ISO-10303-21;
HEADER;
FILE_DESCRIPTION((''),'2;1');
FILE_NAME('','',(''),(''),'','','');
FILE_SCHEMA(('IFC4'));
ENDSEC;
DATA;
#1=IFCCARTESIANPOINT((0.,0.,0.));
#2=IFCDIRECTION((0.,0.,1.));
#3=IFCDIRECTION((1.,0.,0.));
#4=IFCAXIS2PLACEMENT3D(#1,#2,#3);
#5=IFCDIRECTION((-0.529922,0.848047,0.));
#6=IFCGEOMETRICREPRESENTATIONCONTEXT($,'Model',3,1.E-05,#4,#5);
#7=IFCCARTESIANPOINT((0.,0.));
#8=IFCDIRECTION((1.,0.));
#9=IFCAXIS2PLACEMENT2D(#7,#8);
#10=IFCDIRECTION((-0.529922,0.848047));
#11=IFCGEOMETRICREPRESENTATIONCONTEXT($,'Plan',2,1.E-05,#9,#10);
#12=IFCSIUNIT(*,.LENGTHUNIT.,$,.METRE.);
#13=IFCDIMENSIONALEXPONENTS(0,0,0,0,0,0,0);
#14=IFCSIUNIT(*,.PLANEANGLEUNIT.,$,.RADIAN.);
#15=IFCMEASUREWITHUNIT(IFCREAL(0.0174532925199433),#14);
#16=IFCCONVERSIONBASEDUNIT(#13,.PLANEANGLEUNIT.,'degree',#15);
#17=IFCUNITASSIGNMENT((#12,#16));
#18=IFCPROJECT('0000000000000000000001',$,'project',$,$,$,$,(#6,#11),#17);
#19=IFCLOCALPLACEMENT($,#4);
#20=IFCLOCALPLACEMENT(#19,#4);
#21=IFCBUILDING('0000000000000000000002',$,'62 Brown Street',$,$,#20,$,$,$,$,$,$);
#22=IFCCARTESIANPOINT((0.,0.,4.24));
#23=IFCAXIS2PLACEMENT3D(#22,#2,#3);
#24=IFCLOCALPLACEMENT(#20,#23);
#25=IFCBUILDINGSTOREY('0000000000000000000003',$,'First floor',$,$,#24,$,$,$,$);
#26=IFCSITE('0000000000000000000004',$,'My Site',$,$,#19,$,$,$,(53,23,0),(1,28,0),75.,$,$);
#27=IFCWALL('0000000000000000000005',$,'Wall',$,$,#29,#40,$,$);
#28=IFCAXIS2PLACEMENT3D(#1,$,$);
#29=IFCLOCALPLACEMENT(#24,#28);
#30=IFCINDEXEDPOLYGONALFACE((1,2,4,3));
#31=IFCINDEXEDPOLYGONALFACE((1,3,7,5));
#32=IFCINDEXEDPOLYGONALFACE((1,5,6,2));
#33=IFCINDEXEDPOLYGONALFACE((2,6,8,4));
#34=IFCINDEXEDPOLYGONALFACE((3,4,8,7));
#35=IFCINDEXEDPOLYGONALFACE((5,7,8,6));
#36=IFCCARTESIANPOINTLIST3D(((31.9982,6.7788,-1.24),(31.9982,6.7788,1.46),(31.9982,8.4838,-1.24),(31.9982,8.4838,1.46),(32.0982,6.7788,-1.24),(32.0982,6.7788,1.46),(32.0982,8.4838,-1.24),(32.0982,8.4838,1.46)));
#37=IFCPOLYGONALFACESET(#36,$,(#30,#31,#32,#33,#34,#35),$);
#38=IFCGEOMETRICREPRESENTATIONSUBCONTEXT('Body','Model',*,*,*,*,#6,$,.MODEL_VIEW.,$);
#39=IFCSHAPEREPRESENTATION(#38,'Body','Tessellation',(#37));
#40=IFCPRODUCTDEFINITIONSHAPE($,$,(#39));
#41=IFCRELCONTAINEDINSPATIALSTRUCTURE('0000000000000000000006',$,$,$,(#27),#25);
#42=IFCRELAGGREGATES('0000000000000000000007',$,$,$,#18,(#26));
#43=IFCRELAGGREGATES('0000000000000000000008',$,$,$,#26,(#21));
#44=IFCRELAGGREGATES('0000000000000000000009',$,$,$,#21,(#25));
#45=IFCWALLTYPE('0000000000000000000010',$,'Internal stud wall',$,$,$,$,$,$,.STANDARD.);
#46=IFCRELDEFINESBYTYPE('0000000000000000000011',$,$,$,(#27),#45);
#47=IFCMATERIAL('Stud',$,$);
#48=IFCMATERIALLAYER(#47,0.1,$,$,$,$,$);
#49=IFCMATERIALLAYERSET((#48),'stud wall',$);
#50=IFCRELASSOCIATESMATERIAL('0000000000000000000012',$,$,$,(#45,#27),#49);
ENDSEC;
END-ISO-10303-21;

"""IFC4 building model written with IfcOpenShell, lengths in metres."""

from ifc_helpers import new_model, entity, si_unit, converted_unit, direction, frame, origin_with_axes, origin_2d_with_axis, place, context, subcontext, project, spatial, indexed_curve, outline, extrude, material, layer, layer_set, layer_usage, type_object, element, save


model = new_model("IFC4")

# Units and contexts
model_context = context("Model", 3, precision=1e-05, world=origin_with_axes(), true_north=direction((-0.529922, 0.848047, 0.0)))
plan_context = context("Plan", 2, precision=1e-05, world=origin_2d_with_axis(), true_north=direction((-0.529922, 0.848047)))
body_context_1 = subcontext(model_context, "Body", "Model", "MODEL_VIEW")
ifc_project = project(units=[si_unit("LENGTHUNIT", "METRE"), converted_unit("PLANEANGLEUNIT", "degree", entity("IfcReal", 0.0174532925199433), si_unit("PLANEANGLEUNIT", "RADIAN"), dimensions=[0, 0, 0, 0, 0, 0, 0])], contexts=[model_context, plan_context])

# Site, building, storey
site_placement = place(None, origin_with_axes())
site = spatial("IfcSite", under=ifc_project, at=site_placement, Name="My Site", RefLatitude=(53, 23, 0), RefLongitude=(1, 28, 0), RefElevation=75.0)
building_placement = place(site_placement, origin_with_axes())
building = spatial("IfcBuilding", under=site, at=building_placement, Name="62 Brown Street")
storey_placement = place(building_placement, frame((0.0, 0.0, 4.24), z_axis=(0.0, 0.0, 1.0), x_axis=(1.0, 0.0, 0.0)))
storey = spatial("IfcBuildingStorey", under=building, at=storey_placement, Name="First floor")

# Shared definitions
ifc_material_1 = material(Name="Stud")
ifc_layer_1 = layer(ifc_material_1, 0.1)
ifc_layer_set_1 = layer_set([ifc_layer_1], Name="stud wall")
wall_type_1 = type_object("IfcWallType", Name="Internal stud wall", PredefinedType="STANDARD", material=ifc_layer_set_1)

# Wall
ifc_layer_usage_1 = layer_usage(ifc_layer_set_1, "AXIS2", "POSITIVE", 0.0)
wall_1_placement = place(storey_placement, frame((32.0982, 6.7788, -1.24), z_axis=(0.0, 0.0, 1.0), x_axis=(0.000001, 1.0, 0.0)))
element("IfcWall", 1, at=wall_1_placement, inside=storey, type_object=wall_type_1, material=ifc_layer_usage_1, Name="Wall", context=body_context_1, shape_type="SweptSolid", body=[
    extrude(outline(indexed_curve([(0.0, 0.0), (0.0, 0.1), (1.705, 0.1), (1.705, 0.0), (0.0, 0.0)], self_intersect=False)), origin_with_axes(), (0.0, 0.0, 1.0), 2.7),
])

save(model, "model.ifc")
